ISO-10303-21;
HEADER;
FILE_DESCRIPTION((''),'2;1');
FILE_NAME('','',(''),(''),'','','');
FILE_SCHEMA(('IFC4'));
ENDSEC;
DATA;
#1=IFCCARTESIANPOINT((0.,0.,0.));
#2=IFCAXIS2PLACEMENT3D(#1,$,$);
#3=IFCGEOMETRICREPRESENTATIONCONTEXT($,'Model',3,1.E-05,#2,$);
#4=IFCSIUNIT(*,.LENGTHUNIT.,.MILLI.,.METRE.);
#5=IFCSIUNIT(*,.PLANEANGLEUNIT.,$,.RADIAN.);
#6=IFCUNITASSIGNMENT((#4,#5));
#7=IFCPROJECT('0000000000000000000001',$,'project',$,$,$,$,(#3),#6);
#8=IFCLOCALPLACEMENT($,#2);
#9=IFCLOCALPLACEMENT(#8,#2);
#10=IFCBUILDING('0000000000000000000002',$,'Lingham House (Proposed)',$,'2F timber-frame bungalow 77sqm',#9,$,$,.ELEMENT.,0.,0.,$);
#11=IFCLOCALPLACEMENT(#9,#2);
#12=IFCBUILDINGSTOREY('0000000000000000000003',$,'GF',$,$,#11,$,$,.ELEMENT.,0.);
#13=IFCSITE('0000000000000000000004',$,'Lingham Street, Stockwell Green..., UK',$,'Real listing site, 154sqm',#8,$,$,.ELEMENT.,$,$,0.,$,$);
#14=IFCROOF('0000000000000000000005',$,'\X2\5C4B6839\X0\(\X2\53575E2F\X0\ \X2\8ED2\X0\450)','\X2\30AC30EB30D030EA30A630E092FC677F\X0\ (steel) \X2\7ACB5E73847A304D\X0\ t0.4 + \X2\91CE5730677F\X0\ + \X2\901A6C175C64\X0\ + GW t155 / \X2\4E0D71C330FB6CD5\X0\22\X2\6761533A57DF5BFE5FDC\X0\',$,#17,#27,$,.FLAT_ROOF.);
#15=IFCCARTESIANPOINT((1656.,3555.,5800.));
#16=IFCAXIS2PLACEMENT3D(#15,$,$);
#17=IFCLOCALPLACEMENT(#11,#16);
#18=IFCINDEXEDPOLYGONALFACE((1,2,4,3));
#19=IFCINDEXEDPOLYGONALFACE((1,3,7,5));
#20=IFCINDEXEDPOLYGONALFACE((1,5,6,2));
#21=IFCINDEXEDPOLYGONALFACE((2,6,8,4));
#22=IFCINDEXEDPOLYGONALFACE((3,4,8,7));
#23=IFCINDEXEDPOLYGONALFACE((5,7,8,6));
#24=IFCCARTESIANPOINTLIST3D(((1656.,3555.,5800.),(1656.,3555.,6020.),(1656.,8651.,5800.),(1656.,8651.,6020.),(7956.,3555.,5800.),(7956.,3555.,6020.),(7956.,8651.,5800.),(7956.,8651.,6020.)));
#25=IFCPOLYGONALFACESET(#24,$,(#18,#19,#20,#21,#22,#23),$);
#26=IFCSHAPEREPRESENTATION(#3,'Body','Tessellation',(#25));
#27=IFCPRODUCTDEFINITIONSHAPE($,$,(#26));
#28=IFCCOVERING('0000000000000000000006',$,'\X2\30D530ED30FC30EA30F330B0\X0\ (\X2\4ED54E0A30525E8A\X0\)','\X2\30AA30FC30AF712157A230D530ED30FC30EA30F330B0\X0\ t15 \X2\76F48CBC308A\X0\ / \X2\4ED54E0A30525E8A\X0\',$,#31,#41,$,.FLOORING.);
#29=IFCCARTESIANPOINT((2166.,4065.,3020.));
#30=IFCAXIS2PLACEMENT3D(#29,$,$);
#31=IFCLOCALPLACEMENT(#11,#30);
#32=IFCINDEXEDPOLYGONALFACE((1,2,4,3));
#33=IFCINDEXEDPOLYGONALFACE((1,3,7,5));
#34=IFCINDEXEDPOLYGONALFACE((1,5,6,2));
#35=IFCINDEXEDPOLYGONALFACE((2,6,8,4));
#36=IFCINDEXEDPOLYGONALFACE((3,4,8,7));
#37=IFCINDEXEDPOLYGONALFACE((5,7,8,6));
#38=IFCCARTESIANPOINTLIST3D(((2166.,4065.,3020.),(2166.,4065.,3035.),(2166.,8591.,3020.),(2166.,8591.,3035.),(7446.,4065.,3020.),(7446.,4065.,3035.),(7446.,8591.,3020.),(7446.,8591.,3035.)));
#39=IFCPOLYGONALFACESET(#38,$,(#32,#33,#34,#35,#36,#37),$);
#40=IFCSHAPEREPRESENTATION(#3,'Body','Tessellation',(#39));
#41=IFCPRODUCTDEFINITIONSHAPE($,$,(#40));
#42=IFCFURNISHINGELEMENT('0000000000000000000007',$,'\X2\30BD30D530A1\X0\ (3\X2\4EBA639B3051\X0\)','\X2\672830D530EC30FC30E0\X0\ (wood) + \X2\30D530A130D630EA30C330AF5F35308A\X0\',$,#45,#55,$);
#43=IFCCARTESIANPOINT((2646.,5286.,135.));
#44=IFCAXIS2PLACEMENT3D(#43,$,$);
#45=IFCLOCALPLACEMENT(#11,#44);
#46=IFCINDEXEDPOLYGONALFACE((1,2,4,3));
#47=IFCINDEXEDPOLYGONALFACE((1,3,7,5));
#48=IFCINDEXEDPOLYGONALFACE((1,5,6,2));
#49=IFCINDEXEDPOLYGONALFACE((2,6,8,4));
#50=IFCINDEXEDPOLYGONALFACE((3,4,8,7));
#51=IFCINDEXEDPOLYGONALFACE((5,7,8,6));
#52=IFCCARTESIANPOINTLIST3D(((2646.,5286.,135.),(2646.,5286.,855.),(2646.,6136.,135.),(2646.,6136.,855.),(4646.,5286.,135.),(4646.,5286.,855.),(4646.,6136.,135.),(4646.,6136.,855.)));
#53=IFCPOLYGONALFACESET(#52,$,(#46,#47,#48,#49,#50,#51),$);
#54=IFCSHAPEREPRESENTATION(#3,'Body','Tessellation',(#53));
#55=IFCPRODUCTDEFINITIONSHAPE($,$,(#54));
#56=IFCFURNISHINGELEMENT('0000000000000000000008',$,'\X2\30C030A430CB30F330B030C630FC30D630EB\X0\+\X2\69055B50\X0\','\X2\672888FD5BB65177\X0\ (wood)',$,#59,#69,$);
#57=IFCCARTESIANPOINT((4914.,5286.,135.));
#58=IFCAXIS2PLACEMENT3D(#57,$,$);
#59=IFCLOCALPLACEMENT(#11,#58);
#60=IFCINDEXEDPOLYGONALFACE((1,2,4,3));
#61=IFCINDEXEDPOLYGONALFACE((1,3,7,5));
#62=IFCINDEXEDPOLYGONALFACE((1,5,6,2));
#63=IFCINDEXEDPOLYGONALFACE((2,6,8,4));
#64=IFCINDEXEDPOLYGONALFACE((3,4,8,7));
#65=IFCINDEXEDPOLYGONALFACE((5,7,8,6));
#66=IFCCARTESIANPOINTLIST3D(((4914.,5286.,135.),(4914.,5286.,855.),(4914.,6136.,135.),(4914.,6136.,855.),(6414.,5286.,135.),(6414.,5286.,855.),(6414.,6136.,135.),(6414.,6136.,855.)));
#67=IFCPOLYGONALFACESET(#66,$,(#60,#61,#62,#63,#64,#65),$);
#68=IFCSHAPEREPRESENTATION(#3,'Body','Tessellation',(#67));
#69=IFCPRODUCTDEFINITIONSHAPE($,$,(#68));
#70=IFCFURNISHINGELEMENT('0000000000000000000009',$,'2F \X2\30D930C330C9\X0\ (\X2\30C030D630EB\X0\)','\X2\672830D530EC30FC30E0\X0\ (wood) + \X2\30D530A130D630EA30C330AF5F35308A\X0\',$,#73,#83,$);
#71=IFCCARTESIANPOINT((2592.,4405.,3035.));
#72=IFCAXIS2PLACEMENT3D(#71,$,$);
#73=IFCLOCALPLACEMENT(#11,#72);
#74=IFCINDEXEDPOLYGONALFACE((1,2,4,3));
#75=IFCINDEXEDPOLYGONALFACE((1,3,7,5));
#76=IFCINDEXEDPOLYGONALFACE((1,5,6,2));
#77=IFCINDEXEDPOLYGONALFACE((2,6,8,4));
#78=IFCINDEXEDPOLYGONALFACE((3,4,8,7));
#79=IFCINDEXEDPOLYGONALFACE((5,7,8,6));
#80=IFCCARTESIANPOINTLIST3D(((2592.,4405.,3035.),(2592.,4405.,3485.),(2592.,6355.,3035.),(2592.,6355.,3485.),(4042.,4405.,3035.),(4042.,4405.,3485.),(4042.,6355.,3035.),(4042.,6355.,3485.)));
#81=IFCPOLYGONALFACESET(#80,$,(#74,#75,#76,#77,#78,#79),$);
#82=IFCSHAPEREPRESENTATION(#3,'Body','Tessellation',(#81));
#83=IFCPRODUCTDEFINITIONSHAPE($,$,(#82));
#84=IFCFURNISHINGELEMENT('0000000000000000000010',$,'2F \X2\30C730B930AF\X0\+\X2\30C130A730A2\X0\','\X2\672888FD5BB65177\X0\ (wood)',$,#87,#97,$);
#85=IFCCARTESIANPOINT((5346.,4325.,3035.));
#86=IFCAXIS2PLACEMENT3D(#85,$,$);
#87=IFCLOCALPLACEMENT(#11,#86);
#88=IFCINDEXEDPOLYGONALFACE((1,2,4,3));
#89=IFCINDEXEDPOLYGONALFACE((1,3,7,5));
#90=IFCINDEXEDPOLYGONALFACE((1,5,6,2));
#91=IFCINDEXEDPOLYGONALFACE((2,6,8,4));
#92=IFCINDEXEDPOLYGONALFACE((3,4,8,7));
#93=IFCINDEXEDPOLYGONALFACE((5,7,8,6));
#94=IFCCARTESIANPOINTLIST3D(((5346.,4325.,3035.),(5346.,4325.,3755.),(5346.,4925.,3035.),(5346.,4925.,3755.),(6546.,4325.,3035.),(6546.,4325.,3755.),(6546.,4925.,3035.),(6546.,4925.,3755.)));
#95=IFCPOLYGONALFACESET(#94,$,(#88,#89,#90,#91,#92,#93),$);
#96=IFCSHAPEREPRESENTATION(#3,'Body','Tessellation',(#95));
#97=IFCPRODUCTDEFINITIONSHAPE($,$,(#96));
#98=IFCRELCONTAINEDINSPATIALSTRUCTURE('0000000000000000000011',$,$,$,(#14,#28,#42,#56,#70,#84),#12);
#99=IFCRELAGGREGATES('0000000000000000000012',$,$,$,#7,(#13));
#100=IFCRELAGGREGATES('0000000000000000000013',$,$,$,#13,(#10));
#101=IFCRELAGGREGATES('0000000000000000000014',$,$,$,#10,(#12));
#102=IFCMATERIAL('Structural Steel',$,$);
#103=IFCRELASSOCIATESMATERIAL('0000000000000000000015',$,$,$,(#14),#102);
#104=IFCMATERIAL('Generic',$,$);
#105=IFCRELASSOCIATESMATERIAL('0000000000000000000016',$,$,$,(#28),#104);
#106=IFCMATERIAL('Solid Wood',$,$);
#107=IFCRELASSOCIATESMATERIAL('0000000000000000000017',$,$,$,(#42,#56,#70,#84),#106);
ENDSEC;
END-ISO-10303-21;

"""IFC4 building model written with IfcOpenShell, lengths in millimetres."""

from ifc_helpers import new_model, si_unit, frame, frame_2d, origin, place, context, project, spatial, rectangle, extrude, material, element, save


model = new_model("IFC4")

# Units and contexts
model_context = context("Model", 3, precision=1e-05, world=origin())
ifc_project = project(units=[si_unit("LENGTHUNIT", "METRE", prefix="MILLI"), si_unit("PLANEANGLEUNIT", "RADIAN")], contexts=[model_context])

# Site, building, storey
site_placement = place(None, origin())
site = spatial("IfcSite", under=ifc_project, at=site_placement, Name="Lingham Street, Stockwell Green..., UK", ObjectType="Real listing site, 154sqm", CompositionType="ELEMENT", RefElevation=0.0)
building_placement = place(site_placement, origin())
building = spatial("IfcBuilding", under=site, at=building_placement, Name="Lingham House (Proposed)", ObjectType="2F timber-frame bungalow 77sqm", CompositionType="ELEMENT", ElevationOfRefHeight=0.0, ElevationOfTerrain=0.0)
storey_placement = place(building_placement, origin())
storey = spatial("IfcBuildingStorey", under=building, at=storey_placement, Name="GF", CompositionType="ELEMENT", Elevation=0.0)

# Shared definitions
ifc_material_1 = material(Name="Solid Wood")

# Roof
ifc_material_2 = material(Name="Structural Steel")
for number, where, name in (
    (1, (1656.0, 3555.0, 5800.0), "屋根(南帯 軒450)"),
):
    element("IfcRoof", number, at=place(storey_placement, frame(where)), inside=storey, material=ifc_material_2, Name=name, Description="ガルバリウム鋼板 (steel) 立平葺き t0.4 + 野地板 + 通気層 + GW t155 / 不燃・法22条区域対応", PredefinedType="FLAT_ROOF", context=model_context, shape_type="SweptSolid", body=[
        extrude(rectangle(XDim=6300.0, YDim=5096.0, at=frame_2d((3150.0, 2548.0))), frame((1656.0, 3555.0, 5800.0)), (0.0, 0.0, 1.0), 220.0),
    ])

# Covering
ifc_material_3 = material(Name="Generic")
covering_placement = place(storey_placement, frame((2166.0, 4065.0, 3020.0)))
element("IfcCovering", 2, at=covering_placement, inside=storey, material=ifc_material_3, Name="フローリング (仕上げ床)", Description="オーク無垢フローリング t15 直貼り / 仕上げ床", PredefinedType="FLOORING", context=model_context, shape_type="SweptSolid", body=[
    extrude(rectangle(XDim=5280.0, YDim=4526.0, at=frame_2d((2640.0, 2263.0))), frame((2166.0, 4065.0, 3020.0)), (0.0, 0.0, 1.0), 15.0),
])

# Furnishing elements
furnishing_1_placement = place(storey_placement, frame((2646.0, 5286.0, 135.0)))
element("IfcFurnishingElement", 3, at=furnishing_1_placement, inside=storey, material=ifc_material_1, Name="ソファ (3人掛け)", Description="木フレーム (wood) + ファブリック張り", context=model_context, shape_type="SweptSolid", body=[
    extrude(rectangle(XDim=2000.0, YDim=850.0, at=frame_2d((1000.0, 425.0))), frame((2646.0, 5286.0, 135.0)), (0.0, 0.0, 1.0), 720.0),
])
furnishing_2_placement = place(storey_placement, frame((4914.0, 5286.0, 135.0)))
element("IfcFurnishingElement", 4, at=furnishing_2_placement, inside=storey, material=ifc_material_1, Name="ダイニングテーブル+椅子", Description="木製家具 (wood)", context=model_context, shape_type="SweptSolid", body=[
    extrude(rectangle(XDim=1500.0, YDim=850.0, at=frame_2d((750.0, 425.0))), frame((4914.0, 5286.0, 135.0)), (0.0, 0.0, 1.0), 720.0),
])
furnishing_3_placement = place(storey_placement, frame((2592.0, 4405.0, 3035.0)))
element("IfcFurnishingElement", 5, at=furnishing_3_placement, inside=storey, material=ifc_material_1, Name="2F ベッド (ダブル)", Description="木フレーム (wood) + ファブリック張り", context=model_context, shape_type="SweptSolid", body=[
    extrude(rectangle(XDim=1450.0, YDim=1950.0, at=frame_2d((725.0, 975.0))), frame((2592.0, 4405.0, 3035.0)), (0.0, 0.0, 1.0), 450.0),
])
furnishing_4_placement = place(storey_placement, frame((5346.0, 4325.0, 3035.0)))
element("IfcFurnishingElement", 6, at=furnishing_4_placement, inside=storey, material=ifc_material_1, Name="2F デスク+チェア", Description="木製家具 (wood)", context=model_context, shape_type="SweptSolid", body=[
    extrude(rectangle(XDim=1200.0, YDim=600.0, at=frame_2d((600.0, 300.0))), frame((5346.0, 4325.0, 3035.0)), (0.0, 0.0, 1.0), 720.0),
])

save(model, "model.ifc")
